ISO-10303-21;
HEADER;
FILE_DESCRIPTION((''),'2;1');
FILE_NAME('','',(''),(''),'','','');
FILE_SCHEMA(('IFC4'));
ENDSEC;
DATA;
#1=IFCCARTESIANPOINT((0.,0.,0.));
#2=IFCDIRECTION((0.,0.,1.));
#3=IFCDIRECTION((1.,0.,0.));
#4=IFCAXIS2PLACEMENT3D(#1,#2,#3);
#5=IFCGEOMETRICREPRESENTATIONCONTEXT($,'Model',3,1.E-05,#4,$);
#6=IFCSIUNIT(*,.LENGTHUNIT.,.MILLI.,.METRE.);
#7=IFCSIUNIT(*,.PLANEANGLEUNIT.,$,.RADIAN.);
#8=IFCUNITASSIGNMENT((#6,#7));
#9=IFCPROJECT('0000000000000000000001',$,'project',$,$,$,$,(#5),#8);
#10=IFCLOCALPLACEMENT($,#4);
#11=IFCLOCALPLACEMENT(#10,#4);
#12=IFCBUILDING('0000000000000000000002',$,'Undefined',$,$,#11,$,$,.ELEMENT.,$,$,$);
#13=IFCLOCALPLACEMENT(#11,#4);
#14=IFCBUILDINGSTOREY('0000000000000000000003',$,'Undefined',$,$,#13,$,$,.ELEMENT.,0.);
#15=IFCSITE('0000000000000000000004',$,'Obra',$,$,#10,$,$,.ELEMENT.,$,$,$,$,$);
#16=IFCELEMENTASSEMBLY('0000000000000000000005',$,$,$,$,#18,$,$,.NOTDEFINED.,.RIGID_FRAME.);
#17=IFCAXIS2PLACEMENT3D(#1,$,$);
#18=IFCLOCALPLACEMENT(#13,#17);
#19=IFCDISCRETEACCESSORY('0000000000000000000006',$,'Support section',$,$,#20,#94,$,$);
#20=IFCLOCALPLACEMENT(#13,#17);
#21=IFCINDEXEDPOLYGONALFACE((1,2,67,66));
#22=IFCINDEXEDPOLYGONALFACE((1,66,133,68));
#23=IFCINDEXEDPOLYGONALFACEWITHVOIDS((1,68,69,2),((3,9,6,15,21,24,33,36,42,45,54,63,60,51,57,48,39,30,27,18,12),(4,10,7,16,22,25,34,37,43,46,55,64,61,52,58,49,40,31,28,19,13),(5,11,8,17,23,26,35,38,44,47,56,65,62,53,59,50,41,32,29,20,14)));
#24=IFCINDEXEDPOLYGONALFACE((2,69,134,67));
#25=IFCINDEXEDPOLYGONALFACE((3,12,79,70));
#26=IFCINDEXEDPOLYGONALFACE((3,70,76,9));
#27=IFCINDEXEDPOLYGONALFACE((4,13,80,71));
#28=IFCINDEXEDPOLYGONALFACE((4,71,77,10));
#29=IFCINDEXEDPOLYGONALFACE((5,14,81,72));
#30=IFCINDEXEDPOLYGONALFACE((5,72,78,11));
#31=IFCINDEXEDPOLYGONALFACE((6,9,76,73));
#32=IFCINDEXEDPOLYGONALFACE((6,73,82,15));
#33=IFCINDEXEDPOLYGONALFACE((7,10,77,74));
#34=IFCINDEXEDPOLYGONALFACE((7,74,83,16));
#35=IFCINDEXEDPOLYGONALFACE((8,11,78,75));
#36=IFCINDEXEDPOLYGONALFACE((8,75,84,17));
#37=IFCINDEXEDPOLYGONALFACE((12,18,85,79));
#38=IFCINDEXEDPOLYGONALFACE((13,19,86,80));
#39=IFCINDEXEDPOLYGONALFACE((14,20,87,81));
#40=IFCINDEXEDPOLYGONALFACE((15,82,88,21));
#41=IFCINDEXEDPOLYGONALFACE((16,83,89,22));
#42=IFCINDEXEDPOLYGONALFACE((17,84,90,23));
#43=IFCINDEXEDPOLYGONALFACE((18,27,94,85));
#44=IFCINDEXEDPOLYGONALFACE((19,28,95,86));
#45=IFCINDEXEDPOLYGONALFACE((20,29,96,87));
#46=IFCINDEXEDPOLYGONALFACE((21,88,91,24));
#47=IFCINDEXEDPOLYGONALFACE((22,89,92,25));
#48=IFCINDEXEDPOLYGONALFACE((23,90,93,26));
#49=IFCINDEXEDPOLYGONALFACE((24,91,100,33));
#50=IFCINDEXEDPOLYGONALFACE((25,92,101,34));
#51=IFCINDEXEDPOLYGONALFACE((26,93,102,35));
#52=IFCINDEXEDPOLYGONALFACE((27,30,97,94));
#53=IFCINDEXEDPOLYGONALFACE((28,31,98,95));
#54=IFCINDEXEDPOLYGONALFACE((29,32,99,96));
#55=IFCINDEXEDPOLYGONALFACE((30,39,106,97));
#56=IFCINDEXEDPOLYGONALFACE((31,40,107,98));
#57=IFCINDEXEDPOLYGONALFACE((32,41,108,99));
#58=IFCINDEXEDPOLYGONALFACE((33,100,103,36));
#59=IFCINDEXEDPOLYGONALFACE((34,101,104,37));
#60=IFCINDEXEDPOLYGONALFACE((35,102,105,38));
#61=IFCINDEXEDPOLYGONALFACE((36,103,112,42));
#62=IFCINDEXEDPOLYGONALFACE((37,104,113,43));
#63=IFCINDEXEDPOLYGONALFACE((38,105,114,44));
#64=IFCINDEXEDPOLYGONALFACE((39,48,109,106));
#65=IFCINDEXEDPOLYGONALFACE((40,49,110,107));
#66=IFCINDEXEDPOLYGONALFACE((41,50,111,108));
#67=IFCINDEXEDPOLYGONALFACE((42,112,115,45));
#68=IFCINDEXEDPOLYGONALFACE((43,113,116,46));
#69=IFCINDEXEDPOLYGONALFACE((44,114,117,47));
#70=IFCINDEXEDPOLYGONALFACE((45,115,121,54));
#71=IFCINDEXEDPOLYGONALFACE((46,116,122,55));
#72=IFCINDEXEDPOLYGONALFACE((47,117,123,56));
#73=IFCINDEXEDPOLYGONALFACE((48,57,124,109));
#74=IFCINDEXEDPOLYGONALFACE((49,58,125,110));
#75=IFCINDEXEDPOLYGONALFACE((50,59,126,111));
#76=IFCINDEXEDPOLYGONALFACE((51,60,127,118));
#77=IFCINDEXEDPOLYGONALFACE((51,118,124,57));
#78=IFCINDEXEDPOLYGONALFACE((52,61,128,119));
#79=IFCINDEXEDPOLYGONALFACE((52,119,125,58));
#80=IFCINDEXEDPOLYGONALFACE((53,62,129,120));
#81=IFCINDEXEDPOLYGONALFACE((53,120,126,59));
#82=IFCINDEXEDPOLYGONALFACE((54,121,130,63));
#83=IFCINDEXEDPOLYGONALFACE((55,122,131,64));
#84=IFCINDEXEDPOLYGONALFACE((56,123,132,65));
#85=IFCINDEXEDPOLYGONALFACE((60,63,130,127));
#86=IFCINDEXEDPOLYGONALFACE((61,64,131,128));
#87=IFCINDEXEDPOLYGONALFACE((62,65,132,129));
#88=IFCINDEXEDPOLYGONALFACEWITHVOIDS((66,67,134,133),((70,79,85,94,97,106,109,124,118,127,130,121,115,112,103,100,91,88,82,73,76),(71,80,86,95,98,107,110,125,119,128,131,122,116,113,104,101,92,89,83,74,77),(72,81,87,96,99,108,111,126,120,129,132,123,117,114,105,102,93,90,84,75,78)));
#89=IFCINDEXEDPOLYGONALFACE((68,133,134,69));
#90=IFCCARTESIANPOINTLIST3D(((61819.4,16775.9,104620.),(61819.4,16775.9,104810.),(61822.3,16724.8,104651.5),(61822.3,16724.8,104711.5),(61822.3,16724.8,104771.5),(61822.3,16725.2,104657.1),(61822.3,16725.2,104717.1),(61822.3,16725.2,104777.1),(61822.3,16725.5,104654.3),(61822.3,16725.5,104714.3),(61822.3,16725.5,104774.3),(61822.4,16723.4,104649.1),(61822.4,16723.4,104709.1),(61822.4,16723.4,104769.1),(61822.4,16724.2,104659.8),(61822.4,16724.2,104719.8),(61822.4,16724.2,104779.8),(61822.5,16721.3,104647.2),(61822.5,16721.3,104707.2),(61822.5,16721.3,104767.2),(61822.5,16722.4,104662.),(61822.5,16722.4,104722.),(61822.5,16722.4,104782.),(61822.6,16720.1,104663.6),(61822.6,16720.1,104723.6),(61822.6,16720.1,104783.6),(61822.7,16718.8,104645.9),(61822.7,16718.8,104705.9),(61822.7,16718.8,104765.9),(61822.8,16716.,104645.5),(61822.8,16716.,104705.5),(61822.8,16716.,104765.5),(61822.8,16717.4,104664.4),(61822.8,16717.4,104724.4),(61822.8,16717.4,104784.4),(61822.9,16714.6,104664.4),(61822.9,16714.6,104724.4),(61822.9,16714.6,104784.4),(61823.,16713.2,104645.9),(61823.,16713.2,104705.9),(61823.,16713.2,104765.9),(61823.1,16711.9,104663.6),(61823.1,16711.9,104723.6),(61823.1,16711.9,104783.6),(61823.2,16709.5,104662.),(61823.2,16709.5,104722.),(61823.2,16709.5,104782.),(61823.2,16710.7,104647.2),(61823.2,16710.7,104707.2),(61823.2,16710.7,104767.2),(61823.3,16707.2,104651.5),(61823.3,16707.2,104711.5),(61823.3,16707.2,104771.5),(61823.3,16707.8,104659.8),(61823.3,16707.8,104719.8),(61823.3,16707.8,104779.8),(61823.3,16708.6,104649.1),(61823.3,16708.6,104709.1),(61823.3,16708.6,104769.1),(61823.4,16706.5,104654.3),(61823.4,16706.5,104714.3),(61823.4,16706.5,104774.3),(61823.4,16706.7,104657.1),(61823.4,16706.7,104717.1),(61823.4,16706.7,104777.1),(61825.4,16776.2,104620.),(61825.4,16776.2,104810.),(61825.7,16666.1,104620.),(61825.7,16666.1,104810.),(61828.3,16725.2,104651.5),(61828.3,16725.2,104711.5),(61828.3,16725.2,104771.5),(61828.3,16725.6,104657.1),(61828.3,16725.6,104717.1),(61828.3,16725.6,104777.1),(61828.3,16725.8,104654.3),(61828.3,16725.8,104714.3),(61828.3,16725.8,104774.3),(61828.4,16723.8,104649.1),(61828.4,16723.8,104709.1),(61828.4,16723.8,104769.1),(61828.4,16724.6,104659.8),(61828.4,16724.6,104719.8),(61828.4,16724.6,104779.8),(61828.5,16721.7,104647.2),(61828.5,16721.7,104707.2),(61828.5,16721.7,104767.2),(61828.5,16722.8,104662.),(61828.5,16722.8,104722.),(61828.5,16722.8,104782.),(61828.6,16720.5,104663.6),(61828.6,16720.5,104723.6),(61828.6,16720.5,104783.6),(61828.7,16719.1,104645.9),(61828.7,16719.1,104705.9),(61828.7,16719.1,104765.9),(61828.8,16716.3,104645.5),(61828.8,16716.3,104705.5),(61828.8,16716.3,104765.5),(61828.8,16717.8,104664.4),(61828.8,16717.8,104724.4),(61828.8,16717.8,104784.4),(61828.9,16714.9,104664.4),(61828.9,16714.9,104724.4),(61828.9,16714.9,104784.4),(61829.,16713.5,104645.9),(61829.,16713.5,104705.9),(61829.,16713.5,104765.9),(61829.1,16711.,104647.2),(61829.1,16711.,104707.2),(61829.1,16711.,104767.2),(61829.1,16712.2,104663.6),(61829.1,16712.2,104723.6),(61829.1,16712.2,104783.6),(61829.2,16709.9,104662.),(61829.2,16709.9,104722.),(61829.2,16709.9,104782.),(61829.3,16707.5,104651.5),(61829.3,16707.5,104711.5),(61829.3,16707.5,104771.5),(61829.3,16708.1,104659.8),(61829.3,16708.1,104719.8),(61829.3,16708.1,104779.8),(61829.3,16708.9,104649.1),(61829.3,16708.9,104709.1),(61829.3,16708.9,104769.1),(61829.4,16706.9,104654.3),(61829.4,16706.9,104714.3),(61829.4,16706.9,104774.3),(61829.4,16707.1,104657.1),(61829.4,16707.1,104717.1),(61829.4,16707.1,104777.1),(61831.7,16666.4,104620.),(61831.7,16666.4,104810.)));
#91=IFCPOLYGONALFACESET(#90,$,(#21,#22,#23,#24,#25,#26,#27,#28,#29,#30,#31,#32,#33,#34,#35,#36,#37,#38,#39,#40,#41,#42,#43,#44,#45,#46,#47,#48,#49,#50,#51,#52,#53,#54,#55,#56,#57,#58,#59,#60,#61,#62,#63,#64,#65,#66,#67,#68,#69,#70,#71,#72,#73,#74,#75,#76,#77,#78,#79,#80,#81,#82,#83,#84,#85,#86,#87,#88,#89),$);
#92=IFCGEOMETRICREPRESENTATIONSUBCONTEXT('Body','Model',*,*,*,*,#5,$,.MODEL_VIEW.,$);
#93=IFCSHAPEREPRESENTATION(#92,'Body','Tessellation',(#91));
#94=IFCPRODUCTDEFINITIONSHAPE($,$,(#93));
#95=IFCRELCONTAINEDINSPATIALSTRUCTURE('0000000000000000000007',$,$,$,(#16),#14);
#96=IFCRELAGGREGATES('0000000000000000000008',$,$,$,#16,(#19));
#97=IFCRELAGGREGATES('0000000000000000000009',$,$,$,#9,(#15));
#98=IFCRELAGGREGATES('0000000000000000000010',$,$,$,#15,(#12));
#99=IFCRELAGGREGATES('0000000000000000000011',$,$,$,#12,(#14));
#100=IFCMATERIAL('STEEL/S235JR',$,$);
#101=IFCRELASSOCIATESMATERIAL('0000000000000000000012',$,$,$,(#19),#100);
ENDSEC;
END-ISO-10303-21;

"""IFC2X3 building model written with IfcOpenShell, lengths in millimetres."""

from ifc_helpers import new_model, si_unit, frame, origin_with_axes, origin_2d_with_axis, place, context, subcontext, project, spatial, rectangle, circle, extrude, source, transform, mapped, material, element, aggregate, save


model = new_model("IFC2X3")

# Units and contexts
model_context = context("Model", 3, precision=1e-05, world=origin_with_axes())
body_context = subcontext(model_context, "Body", "Model", "MODEL_VIEW")
ifc_project = project(units=[si_unit("LENGTHUNIT", "METRE", prefix="MILLI"), si_unit("PLANEANGLEUNIT", "RADIAN")], contexts=[model_context])

# Site, building, storey
site_placement = place(None, origin_with_axes())
site = spatial("IfcSite", under=ifc_project, at=site_placement, Name="Obra", CompositionType="ELEMENT")
building_placement = place(site_placement, origin_with_axes())
building = spatial("IfcBuilding", under=site, at=building_placement, Name="Undefined", CompositionType="ELEMENT")
storey_placement = place(building_placement, origin_with_axes())
storey = spatial("IfcBuildingStorey", under=building, at=storey_placement, Name="Undefined", CompositionType="ELEMENT", Elevation=0.0)

# Element assembly
assembly_1_placement = place(storey_placement, origin_with_axes())
assembly_1 = element("IfcElementAssembly", 1, at=assembly_1_placement, inside=storey, AssemblyPlace="NOTDEFINED", PredefinedType="RIGID_FRAME")
ifc_material = material(Name="STEEL/S235JR")

# Shared definitions
shared_shape_1 = source(origin_with_axes(), body_context, "Body", "SweptSolid", [
    extrude(circle(Radius=9.5, at=origin_2d_with_axis()), frame((0.0, -9.2, 0.0), z_axis=(0.0, 1.0, 0.0), x_axis=(1.0, 0.0, 0.0)), (0.0, 0.0, 1.0), 6.2),
])

# Discrete accessory, opening
discrete_accessory_1_placement = place(assembly_1_placement, frame((61825.6, 16721.2, 104620.0), z_axis=(0.0, 0.0, 1.0), x_axis=(-0.057107, 0.998368, 0.0)))
discrete_accessory_1 = element("IfcDiscreteAccessory", 2, at=discrete_accessory_1_placement, material=ifc_material, Name="Support section", context=body_context, shape_type="SweptSolid", body=[
    extrude(rectangle(XDim=6.0, YDim=110.0, at=origin_2d_with_axis()), frame((0.0, 0.0, 190.0), z_axis=(0.0, 0.0, -1.0), x_axis=(0.0, 1.0, 0.0)), (0.0, 0.0, 1.0), 190.0),
])
opening_1_placement = place(assembly_1_placement, frame((61829.1, 16766.4, 104835.0), z_axis=(0.057107, -0.998368, 0.0), x_axis=(0.0, 0.0, -1.0)))
element("IfcOpeningElement", 3, at=opening_1_placement, cuts=discrete_accessory_1, ObjectType="Opening", context=body_context, shape_type="MappedRepresentation", body=[
    mapped(shared_shape_1, transform((60.0, 0.0, 50.0))),
    mapped(shared_shape_1, transform((120.0, 0.0, 50.0))),
    mapped(shared_shape_1, transform((180.0, 0.0, 50.0))),
])
aggregate(assembly_1, [discrete_accessory_1])

save(model, "model.ifc")
